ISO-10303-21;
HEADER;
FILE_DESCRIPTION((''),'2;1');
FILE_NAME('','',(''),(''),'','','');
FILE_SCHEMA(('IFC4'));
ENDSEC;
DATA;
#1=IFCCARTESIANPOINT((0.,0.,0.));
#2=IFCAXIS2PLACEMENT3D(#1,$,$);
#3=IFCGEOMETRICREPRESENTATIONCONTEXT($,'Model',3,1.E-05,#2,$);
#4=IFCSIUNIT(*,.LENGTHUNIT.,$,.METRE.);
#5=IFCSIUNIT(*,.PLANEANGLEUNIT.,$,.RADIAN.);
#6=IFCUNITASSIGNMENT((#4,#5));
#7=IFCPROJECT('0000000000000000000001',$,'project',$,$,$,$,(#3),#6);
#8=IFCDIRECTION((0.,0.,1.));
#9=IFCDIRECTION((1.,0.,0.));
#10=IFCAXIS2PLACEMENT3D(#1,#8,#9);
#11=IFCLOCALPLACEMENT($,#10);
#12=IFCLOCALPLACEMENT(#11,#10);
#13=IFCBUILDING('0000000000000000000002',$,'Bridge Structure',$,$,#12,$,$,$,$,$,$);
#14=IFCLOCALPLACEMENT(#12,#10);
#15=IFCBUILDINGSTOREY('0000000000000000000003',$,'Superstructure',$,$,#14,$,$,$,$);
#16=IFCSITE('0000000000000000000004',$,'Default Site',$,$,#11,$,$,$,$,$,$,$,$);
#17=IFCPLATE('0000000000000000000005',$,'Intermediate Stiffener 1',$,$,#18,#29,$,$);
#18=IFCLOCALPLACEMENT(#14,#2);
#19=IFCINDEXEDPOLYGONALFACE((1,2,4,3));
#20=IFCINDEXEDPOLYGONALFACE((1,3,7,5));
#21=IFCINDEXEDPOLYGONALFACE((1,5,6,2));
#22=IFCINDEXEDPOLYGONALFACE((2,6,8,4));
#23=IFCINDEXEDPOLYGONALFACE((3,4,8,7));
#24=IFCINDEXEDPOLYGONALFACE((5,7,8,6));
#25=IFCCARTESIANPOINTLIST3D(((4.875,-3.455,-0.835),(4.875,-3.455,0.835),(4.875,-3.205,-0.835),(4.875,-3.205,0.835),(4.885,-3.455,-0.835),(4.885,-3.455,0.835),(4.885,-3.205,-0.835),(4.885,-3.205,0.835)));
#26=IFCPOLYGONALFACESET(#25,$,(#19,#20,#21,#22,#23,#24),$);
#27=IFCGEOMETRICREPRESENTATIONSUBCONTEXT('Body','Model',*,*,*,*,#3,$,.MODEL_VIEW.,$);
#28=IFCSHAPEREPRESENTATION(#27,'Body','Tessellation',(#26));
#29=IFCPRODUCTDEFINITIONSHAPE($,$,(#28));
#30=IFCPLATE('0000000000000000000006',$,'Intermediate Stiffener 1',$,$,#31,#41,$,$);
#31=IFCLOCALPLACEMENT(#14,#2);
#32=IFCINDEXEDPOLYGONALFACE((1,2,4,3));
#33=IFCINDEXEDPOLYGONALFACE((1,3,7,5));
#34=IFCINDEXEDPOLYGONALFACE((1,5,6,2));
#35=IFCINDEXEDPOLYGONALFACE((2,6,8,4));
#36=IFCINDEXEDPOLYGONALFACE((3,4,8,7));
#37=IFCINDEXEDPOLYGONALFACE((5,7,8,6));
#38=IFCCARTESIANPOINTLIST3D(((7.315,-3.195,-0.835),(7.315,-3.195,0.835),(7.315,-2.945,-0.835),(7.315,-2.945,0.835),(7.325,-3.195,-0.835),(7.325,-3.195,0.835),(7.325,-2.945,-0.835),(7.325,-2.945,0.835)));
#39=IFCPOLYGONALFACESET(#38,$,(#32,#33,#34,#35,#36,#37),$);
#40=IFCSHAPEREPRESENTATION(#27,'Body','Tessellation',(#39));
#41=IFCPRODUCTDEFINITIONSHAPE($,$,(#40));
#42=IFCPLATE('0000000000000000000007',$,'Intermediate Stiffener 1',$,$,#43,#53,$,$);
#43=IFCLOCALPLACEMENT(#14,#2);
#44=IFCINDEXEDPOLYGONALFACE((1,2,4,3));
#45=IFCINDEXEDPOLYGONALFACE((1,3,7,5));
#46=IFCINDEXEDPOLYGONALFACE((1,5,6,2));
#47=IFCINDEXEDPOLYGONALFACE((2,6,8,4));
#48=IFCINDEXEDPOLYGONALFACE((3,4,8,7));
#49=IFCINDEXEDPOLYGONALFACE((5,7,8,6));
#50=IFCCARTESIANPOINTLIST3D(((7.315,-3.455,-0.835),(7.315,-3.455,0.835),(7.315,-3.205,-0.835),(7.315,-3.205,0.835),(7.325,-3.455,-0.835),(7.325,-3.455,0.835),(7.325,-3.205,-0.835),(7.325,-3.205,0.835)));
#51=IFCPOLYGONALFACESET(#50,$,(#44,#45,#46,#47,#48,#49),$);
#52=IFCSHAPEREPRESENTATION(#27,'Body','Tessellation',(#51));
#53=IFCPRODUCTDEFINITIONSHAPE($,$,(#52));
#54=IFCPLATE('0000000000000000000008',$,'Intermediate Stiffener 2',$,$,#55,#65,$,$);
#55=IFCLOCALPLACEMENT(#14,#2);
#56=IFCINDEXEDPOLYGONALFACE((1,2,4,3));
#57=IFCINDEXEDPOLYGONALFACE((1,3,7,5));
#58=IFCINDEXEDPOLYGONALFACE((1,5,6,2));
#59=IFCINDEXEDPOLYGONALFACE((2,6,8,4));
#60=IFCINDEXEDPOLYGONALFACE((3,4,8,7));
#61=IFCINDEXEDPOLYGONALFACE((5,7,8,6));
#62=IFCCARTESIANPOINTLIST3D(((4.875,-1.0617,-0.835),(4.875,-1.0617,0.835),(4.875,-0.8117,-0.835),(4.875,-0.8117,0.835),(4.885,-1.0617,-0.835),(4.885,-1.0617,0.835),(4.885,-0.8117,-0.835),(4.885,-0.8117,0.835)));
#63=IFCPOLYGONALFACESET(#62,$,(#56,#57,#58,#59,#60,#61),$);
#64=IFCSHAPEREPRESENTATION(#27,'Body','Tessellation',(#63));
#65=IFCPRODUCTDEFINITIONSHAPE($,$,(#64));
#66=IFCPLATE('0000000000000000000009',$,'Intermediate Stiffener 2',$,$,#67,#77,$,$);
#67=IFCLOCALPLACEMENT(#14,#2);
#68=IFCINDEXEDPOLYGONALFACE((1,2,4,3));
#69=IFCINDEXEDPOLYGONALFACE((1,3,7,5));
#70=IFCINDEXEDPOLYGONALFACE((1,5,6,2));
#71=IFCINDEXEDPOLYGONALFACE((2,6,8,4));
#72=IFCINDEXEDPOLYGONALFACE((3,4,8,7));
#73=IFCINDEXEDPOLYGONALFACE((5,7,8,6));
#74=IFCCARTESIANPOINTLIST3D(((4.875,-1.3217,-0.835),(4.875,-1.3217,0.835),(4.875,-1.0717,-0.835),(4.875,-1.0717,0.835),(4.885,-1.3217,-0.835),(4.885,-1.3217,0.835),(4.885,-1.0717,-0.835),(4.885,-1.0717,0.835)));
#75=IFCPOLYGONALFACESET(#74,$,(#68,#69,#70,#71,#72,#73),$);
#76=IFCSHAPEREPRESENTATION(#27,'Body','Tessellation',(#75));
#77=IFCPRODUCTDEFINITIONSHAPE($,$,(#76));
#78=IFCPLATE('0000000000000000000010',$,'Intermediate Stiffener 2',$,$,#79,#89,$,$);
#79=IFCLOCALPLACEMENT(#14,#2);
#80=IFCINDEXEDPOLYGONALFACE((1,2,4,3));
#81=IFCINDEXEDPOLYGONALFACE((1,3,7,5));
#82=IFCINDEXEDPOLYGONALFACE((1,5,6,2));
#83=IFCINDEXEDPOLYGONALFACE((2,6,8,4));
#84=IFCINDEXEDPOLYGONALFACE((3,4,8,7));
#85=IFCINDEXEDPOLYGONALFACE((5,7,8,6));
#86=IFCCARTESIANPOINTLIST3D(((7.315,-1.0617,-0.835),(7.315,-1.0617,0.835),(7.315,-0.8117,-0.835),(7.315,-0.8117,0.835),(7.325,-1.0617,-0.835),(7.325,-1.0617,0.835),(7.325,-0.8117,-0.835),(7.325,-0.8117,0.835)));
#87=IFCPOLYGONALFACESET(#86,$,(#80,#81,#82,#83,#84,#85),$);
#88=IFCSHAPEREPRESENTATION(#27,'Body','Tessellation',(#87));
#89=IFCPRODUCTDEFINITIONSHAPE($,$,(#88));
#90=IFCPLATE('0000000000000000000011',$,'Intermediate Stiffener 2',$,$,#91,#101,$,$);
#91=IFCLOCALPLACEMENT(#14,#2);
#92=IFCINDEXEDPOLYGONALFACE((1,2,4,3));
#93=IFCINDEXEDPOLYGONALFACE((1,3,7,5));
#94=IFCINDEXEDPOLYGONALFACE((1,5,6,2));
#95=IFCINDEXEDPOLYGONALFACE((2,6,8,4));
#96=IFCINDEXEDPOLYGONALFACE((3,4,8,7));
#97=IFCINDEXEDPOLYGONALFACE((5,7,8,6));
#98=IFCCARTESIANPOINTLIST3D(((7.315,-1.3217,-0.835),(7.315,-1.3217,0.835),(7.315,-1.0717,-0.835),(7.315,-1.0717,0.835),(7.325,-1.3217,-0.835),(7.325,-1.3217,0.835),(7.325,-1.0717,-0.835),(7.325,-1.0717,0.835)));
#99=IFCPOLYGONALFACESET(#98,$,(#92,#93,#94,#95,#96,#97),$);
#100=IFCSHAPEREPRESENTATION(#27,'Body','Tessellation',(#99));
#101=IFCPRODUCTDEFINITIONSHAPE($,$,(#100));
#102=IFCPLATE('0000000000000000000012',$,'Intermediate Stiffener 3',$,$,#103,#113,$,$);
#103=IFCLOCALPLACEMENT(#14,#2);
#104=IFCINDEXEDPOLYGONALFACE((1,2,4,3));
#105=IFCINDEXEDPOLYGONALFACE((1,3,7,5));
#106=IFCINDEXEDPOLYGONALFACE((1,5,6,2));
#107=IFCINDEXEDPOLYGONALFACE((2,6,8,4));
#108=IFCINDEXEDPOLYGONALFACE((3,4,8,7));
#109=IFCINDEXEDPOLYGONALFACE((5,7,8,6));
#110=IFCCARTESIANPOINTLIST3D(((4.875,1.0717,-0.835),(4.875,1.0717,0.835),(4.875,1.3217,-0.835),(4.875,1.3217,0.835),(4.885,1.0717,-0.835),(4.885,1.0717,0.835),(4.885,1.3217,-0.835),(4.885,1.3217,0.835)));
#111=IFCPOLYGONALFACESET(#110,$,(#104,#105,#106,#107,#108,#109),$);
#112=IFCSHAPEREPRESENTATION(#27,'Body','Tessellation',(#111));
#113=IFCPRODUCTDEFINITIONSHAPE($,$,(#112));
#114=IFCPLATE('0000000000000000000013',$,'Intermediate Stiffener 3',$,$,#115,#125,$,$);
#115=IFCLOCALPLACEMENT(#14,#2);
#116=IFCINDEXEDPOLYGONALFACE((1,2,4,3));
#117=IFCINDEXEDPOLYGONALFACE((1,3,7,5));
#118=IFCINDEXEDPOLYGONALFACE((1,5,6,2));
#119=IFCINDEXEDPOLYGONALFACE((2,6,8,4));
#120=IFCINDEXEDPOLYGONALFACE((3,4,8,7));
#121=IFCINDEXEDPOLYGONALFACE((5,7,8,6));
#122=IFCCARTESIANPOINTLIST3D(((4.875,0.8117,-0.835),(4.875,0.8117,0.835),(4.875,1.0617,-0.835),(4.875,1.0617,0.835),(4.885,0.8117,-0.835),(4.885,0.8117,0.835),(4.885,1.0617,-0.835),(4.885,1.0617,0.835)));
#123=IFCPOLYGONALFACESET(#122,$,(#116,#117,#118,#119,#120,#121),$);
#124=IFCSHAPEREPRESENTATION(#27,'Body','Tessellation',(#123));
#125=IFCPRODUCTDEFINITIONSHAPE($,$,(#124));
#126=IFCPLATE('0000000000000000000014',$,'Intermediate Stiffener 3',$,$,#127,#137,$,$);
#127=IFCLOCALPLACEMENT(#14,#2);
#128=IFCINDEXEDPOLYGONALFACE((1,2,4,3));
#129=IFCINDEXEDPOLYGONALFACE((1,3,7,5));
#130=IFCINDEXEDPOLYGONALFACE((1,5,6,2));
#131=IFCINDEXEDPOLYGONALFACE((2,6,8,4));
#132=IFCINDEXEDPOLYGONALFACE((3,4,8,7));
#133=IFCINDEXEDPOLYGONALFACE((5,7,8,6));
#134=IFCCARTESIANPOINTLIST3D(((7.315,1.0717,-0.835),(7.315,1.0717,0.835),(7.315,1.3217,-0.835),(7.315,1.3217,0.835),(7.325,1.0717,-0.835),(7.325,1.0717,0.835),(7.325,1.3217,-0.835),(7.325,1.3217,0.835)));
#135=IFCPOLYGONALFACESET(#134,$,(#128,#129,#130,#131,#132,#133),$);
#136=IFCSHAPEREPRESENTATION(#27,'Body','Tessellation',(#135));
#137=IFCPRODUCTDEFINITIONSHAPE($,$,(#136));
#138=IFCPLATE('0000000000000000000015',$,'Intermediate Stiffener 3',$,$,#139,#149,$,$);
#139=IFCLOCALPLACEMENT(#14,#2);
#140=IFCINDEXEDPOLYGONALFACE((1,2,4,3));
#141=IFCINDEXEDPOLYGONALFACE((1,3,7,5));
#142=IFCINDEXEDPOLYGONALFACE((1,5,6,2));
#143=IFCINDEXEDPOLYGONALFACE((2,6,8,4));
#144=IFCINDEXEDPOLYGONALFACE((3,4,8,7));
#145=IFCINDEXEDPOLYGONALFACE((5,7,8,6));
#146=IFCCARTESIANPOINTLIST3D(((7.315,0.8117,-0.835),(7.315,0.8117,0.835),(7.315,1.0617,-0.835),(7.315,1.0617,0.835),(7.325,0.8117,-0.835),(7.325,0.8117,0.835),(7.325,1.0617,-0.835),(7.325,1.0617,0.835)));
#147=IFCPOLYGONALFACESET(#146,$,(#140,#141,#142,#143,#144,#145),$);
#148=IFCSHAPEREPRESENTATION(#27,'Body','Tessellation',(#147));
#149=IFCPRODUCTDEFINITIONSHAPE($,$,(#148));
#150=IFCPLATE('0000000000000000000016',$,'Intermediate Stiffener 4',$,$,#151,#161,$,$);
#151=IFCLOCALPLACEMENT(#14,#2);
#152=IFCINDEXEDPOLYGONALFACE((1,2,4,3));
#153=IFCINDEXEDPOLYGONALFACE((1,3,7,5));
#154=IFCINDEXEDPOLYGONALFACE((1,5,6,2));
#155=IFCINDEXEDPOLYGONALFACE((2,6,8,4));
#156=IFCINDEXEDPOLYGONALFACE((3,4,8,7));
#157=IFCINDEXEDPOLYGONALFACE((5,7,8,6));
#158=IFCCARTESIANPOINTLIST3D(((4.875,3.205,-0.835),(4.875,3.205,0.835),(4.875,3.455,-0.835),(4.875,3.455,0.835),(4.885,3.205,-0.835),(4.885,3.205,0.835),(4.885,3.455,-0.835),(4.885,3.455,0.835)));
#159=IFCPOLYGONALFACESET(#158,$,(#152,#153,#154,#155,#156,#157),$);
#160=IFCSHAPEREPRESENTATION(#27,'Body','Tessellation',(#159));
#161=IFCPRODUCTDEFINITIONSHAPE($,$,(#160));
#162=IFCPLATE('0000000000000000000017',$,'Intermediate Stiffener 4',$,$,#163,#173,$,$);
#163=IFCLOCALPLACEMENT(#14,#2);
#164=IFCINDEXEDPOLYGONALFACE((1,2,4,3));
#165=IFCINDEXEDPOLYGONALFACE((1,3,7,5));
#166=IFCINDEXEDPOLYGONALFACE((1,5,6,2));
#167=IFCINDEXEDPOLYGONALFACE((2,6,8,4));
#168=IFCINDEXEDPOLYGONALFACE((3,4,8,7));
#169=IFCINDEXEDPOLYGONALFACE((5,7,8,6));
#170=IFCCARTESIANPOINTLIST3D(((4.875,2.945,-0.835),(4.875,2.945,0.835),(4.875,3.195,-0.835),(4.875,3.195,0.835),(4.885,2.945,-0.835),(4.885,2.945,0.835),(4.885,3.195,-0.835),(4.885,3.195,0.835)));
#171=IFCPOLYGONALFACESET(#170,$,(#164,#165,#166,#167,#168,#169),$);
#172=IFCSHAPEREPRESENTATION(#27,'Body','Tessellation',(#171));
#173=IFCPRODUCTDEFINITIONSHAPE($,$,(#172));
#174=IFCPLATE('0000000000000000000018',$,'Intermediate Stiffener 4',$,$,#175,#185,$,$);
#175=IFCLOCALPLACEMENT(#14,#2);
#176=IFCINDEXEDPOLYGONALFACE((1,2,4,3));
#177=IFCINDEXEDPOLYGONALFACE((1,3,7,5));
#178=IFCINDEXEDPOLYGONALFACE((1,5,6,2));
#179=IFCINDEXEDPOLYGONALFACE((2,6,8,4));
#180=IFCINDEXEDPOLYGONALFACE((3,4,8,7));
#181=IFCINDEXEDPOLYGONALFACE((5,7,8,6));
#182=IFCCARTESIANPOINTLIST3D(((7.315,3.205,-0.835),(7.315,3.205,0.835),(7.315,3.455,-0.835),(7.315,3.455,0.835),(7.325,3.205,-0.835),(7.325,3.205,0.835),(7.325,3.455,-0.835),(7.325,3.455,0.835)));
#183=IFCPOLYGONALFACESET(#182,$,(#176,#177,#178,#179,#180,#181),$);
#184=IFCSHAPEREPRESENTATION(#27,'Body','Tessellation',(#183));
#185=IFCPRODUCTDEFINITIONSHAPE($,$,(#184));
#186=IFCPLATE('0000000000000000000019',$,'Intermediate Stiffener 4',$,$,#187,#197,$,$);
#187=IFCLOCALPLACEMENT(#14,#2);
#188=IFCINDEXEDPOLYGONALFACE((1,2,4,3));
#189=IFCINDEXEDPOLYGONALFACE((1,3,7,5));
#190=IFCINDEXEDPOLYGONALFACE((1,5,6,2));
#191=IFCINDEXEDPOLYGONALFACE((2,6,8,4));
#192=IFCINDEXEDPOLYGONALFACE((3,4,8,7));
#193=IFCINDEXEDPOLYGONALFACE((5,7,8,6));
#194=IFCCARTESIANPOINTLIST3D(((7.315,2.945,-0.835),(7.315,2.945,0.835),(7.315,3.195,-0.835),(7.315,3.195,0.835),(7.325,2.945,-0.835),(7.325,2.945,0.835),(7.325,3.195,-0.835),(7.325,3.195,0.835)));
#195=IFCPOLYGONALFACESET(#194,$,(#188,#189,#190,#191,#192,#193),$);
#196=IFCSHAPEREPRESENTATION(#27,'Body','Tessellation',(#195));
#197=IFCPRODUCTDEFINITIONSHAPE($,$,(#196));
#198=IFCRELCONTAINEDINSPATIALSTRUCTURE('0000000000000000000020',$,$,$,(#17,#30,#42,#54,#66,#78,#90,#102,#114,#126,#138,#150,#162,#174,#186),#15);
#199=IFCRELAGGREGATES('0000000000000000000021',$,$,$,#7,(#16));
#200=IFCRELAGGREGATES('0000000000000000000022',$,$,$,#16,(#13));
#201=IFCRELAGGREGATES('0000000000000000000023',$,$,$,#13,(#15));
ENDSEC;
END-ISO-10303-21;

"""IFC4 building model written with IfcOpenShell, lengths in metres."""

from ifc_helpers import new_model, si_unit, frame, origin, origin_with_axes, origin_2d_with_axis, place, context, subcontext, project, spatial, rectangle, extrude, element, save


model = new_model("IFC4")

# Units and contexts
model_context = context("Model", 3, precision=1e-05, world=origin())
body_context = subcontext(model_context, "Body", "Model", "MODEL_VIEW")
ifc_project = project(units=[si_unit("LENGTHUNIT", "METRE"), si_unit("PLANEANGLEUNIT", "RADIAN")], contexts=[model_context])

# Site, building, storey
site_placement = place(None, origin_with_axes())
site = spatial("IfcSite", under=ifc_project, at=site_placement, Name="Default Site")
building_placement = place(site_placement, origin_with_axes())
building = spatial("IfcBuilding", under=site, at=building_placement, Name="Bridge Structure")
storey_placement = place(building_placement, origin_with_axes())
storey = spatial("IfcBuildingStorey", under=building, at=storey_placement, Name="Superstructure")

# Plates
for number, where, z_axis, x_axis, name in (
    (1, (4.88, -3.33, -0.835), (0.0, 0.0, 1.0), (1.0, 0.0, 0.0), "Intermediate Stiffener 1"),
    (2, (7.32, -3.07, -0.835), (0.0, 0.0, 1.0), (1.0, 0.0, 0.0), "Intermediate Stiffener 1"),
    (3, (7.32, -3.33, -0.835), (0.0, 0.0, 1.0), (1.0, 0.0, 0.0), "Intermediate Stiffener 1"),
    (4, (4.88, -0.9367, -0.835), (0.0, 0.0, 1.0), (1.0, 0.0, 0.0), "Intermediate Stiffener 2"),
    (5, (4.88, -1.1967, -0.835), (0.0, 0.0, 1.0), (1.0, 0.0, 0.0), "Intermediate Stiffener 2"),
    (6, (7.32, -0.9367, -0.835), (0.0, 0.0, 1.0), (1.0, 0.0, 0.0), "Intermediate Stiffener 2"),
    (7, (7.32, -1.1967, -0.835), (0.0, 0.0, 1.0), (1.0, 0.0, 0.0), "Intermediate Stiffener 2"),
    (8, (4.88, 1.1967, -0.835), (0.0, 0.0, 1.0), (1.0, 0.0, 0.0), "Intermediate Stiffener 3"),
    (9, (4.88, 0.9367, -0.835), (0.0, 0.0, 1.0), (1.0, 0.0, 0.0), "Intermediate Stiffener 3"),
    (10, (7.32, 1.1967, -0.835), (0.0, 0.0, 1.0), (1.0, 0.0, 0.0), "Intermediate Stiffener 3"),
    (11, (7.32, 0.9367, -0.835), (0.0, 0.0, 1.0), (1.0, 0.0, 0.0), "Intermediate Stiffener 3"),
    (12, (4.88, 3.33, -0.835), (0.0, 0.0, 1.0), (1.0, 0.0, 0.0), "Intermediate Stiffener 4"),
    (13, (4.88, 3.07, -0.835), (0.0, 0.0, 1.0), (1.0, 0.0, 0.0), "Intermediate Stiffener 4"),
    (14, (7.32, 3.33, -0.835), (0.0, 0.0, 1.0), (1.0, 0.0, 0.0), "Intermediate Stiffener 4"),
    (15, (7.32, 3.07, -0.835), (0.0, 0.0, 1.0), (1.0, 0.0, 0.0), "Intermediate Stiffener 4"),
):
    element("IfcPlate", number, at=place(storey_placement, frame(where, z_axis=z_axis, x_axis=x_axis)), inside=storey, Name=name, context=body_context, shape_type="SweptSolid", body=[
        extrude(rectangle(XDim=0.01, YDim=0.25, at=origin_2d_with_axis()), origin_with_axes(), (0.0, 0.0, 1.0), 1.67),
    ])

save(model, "model.ifc")
